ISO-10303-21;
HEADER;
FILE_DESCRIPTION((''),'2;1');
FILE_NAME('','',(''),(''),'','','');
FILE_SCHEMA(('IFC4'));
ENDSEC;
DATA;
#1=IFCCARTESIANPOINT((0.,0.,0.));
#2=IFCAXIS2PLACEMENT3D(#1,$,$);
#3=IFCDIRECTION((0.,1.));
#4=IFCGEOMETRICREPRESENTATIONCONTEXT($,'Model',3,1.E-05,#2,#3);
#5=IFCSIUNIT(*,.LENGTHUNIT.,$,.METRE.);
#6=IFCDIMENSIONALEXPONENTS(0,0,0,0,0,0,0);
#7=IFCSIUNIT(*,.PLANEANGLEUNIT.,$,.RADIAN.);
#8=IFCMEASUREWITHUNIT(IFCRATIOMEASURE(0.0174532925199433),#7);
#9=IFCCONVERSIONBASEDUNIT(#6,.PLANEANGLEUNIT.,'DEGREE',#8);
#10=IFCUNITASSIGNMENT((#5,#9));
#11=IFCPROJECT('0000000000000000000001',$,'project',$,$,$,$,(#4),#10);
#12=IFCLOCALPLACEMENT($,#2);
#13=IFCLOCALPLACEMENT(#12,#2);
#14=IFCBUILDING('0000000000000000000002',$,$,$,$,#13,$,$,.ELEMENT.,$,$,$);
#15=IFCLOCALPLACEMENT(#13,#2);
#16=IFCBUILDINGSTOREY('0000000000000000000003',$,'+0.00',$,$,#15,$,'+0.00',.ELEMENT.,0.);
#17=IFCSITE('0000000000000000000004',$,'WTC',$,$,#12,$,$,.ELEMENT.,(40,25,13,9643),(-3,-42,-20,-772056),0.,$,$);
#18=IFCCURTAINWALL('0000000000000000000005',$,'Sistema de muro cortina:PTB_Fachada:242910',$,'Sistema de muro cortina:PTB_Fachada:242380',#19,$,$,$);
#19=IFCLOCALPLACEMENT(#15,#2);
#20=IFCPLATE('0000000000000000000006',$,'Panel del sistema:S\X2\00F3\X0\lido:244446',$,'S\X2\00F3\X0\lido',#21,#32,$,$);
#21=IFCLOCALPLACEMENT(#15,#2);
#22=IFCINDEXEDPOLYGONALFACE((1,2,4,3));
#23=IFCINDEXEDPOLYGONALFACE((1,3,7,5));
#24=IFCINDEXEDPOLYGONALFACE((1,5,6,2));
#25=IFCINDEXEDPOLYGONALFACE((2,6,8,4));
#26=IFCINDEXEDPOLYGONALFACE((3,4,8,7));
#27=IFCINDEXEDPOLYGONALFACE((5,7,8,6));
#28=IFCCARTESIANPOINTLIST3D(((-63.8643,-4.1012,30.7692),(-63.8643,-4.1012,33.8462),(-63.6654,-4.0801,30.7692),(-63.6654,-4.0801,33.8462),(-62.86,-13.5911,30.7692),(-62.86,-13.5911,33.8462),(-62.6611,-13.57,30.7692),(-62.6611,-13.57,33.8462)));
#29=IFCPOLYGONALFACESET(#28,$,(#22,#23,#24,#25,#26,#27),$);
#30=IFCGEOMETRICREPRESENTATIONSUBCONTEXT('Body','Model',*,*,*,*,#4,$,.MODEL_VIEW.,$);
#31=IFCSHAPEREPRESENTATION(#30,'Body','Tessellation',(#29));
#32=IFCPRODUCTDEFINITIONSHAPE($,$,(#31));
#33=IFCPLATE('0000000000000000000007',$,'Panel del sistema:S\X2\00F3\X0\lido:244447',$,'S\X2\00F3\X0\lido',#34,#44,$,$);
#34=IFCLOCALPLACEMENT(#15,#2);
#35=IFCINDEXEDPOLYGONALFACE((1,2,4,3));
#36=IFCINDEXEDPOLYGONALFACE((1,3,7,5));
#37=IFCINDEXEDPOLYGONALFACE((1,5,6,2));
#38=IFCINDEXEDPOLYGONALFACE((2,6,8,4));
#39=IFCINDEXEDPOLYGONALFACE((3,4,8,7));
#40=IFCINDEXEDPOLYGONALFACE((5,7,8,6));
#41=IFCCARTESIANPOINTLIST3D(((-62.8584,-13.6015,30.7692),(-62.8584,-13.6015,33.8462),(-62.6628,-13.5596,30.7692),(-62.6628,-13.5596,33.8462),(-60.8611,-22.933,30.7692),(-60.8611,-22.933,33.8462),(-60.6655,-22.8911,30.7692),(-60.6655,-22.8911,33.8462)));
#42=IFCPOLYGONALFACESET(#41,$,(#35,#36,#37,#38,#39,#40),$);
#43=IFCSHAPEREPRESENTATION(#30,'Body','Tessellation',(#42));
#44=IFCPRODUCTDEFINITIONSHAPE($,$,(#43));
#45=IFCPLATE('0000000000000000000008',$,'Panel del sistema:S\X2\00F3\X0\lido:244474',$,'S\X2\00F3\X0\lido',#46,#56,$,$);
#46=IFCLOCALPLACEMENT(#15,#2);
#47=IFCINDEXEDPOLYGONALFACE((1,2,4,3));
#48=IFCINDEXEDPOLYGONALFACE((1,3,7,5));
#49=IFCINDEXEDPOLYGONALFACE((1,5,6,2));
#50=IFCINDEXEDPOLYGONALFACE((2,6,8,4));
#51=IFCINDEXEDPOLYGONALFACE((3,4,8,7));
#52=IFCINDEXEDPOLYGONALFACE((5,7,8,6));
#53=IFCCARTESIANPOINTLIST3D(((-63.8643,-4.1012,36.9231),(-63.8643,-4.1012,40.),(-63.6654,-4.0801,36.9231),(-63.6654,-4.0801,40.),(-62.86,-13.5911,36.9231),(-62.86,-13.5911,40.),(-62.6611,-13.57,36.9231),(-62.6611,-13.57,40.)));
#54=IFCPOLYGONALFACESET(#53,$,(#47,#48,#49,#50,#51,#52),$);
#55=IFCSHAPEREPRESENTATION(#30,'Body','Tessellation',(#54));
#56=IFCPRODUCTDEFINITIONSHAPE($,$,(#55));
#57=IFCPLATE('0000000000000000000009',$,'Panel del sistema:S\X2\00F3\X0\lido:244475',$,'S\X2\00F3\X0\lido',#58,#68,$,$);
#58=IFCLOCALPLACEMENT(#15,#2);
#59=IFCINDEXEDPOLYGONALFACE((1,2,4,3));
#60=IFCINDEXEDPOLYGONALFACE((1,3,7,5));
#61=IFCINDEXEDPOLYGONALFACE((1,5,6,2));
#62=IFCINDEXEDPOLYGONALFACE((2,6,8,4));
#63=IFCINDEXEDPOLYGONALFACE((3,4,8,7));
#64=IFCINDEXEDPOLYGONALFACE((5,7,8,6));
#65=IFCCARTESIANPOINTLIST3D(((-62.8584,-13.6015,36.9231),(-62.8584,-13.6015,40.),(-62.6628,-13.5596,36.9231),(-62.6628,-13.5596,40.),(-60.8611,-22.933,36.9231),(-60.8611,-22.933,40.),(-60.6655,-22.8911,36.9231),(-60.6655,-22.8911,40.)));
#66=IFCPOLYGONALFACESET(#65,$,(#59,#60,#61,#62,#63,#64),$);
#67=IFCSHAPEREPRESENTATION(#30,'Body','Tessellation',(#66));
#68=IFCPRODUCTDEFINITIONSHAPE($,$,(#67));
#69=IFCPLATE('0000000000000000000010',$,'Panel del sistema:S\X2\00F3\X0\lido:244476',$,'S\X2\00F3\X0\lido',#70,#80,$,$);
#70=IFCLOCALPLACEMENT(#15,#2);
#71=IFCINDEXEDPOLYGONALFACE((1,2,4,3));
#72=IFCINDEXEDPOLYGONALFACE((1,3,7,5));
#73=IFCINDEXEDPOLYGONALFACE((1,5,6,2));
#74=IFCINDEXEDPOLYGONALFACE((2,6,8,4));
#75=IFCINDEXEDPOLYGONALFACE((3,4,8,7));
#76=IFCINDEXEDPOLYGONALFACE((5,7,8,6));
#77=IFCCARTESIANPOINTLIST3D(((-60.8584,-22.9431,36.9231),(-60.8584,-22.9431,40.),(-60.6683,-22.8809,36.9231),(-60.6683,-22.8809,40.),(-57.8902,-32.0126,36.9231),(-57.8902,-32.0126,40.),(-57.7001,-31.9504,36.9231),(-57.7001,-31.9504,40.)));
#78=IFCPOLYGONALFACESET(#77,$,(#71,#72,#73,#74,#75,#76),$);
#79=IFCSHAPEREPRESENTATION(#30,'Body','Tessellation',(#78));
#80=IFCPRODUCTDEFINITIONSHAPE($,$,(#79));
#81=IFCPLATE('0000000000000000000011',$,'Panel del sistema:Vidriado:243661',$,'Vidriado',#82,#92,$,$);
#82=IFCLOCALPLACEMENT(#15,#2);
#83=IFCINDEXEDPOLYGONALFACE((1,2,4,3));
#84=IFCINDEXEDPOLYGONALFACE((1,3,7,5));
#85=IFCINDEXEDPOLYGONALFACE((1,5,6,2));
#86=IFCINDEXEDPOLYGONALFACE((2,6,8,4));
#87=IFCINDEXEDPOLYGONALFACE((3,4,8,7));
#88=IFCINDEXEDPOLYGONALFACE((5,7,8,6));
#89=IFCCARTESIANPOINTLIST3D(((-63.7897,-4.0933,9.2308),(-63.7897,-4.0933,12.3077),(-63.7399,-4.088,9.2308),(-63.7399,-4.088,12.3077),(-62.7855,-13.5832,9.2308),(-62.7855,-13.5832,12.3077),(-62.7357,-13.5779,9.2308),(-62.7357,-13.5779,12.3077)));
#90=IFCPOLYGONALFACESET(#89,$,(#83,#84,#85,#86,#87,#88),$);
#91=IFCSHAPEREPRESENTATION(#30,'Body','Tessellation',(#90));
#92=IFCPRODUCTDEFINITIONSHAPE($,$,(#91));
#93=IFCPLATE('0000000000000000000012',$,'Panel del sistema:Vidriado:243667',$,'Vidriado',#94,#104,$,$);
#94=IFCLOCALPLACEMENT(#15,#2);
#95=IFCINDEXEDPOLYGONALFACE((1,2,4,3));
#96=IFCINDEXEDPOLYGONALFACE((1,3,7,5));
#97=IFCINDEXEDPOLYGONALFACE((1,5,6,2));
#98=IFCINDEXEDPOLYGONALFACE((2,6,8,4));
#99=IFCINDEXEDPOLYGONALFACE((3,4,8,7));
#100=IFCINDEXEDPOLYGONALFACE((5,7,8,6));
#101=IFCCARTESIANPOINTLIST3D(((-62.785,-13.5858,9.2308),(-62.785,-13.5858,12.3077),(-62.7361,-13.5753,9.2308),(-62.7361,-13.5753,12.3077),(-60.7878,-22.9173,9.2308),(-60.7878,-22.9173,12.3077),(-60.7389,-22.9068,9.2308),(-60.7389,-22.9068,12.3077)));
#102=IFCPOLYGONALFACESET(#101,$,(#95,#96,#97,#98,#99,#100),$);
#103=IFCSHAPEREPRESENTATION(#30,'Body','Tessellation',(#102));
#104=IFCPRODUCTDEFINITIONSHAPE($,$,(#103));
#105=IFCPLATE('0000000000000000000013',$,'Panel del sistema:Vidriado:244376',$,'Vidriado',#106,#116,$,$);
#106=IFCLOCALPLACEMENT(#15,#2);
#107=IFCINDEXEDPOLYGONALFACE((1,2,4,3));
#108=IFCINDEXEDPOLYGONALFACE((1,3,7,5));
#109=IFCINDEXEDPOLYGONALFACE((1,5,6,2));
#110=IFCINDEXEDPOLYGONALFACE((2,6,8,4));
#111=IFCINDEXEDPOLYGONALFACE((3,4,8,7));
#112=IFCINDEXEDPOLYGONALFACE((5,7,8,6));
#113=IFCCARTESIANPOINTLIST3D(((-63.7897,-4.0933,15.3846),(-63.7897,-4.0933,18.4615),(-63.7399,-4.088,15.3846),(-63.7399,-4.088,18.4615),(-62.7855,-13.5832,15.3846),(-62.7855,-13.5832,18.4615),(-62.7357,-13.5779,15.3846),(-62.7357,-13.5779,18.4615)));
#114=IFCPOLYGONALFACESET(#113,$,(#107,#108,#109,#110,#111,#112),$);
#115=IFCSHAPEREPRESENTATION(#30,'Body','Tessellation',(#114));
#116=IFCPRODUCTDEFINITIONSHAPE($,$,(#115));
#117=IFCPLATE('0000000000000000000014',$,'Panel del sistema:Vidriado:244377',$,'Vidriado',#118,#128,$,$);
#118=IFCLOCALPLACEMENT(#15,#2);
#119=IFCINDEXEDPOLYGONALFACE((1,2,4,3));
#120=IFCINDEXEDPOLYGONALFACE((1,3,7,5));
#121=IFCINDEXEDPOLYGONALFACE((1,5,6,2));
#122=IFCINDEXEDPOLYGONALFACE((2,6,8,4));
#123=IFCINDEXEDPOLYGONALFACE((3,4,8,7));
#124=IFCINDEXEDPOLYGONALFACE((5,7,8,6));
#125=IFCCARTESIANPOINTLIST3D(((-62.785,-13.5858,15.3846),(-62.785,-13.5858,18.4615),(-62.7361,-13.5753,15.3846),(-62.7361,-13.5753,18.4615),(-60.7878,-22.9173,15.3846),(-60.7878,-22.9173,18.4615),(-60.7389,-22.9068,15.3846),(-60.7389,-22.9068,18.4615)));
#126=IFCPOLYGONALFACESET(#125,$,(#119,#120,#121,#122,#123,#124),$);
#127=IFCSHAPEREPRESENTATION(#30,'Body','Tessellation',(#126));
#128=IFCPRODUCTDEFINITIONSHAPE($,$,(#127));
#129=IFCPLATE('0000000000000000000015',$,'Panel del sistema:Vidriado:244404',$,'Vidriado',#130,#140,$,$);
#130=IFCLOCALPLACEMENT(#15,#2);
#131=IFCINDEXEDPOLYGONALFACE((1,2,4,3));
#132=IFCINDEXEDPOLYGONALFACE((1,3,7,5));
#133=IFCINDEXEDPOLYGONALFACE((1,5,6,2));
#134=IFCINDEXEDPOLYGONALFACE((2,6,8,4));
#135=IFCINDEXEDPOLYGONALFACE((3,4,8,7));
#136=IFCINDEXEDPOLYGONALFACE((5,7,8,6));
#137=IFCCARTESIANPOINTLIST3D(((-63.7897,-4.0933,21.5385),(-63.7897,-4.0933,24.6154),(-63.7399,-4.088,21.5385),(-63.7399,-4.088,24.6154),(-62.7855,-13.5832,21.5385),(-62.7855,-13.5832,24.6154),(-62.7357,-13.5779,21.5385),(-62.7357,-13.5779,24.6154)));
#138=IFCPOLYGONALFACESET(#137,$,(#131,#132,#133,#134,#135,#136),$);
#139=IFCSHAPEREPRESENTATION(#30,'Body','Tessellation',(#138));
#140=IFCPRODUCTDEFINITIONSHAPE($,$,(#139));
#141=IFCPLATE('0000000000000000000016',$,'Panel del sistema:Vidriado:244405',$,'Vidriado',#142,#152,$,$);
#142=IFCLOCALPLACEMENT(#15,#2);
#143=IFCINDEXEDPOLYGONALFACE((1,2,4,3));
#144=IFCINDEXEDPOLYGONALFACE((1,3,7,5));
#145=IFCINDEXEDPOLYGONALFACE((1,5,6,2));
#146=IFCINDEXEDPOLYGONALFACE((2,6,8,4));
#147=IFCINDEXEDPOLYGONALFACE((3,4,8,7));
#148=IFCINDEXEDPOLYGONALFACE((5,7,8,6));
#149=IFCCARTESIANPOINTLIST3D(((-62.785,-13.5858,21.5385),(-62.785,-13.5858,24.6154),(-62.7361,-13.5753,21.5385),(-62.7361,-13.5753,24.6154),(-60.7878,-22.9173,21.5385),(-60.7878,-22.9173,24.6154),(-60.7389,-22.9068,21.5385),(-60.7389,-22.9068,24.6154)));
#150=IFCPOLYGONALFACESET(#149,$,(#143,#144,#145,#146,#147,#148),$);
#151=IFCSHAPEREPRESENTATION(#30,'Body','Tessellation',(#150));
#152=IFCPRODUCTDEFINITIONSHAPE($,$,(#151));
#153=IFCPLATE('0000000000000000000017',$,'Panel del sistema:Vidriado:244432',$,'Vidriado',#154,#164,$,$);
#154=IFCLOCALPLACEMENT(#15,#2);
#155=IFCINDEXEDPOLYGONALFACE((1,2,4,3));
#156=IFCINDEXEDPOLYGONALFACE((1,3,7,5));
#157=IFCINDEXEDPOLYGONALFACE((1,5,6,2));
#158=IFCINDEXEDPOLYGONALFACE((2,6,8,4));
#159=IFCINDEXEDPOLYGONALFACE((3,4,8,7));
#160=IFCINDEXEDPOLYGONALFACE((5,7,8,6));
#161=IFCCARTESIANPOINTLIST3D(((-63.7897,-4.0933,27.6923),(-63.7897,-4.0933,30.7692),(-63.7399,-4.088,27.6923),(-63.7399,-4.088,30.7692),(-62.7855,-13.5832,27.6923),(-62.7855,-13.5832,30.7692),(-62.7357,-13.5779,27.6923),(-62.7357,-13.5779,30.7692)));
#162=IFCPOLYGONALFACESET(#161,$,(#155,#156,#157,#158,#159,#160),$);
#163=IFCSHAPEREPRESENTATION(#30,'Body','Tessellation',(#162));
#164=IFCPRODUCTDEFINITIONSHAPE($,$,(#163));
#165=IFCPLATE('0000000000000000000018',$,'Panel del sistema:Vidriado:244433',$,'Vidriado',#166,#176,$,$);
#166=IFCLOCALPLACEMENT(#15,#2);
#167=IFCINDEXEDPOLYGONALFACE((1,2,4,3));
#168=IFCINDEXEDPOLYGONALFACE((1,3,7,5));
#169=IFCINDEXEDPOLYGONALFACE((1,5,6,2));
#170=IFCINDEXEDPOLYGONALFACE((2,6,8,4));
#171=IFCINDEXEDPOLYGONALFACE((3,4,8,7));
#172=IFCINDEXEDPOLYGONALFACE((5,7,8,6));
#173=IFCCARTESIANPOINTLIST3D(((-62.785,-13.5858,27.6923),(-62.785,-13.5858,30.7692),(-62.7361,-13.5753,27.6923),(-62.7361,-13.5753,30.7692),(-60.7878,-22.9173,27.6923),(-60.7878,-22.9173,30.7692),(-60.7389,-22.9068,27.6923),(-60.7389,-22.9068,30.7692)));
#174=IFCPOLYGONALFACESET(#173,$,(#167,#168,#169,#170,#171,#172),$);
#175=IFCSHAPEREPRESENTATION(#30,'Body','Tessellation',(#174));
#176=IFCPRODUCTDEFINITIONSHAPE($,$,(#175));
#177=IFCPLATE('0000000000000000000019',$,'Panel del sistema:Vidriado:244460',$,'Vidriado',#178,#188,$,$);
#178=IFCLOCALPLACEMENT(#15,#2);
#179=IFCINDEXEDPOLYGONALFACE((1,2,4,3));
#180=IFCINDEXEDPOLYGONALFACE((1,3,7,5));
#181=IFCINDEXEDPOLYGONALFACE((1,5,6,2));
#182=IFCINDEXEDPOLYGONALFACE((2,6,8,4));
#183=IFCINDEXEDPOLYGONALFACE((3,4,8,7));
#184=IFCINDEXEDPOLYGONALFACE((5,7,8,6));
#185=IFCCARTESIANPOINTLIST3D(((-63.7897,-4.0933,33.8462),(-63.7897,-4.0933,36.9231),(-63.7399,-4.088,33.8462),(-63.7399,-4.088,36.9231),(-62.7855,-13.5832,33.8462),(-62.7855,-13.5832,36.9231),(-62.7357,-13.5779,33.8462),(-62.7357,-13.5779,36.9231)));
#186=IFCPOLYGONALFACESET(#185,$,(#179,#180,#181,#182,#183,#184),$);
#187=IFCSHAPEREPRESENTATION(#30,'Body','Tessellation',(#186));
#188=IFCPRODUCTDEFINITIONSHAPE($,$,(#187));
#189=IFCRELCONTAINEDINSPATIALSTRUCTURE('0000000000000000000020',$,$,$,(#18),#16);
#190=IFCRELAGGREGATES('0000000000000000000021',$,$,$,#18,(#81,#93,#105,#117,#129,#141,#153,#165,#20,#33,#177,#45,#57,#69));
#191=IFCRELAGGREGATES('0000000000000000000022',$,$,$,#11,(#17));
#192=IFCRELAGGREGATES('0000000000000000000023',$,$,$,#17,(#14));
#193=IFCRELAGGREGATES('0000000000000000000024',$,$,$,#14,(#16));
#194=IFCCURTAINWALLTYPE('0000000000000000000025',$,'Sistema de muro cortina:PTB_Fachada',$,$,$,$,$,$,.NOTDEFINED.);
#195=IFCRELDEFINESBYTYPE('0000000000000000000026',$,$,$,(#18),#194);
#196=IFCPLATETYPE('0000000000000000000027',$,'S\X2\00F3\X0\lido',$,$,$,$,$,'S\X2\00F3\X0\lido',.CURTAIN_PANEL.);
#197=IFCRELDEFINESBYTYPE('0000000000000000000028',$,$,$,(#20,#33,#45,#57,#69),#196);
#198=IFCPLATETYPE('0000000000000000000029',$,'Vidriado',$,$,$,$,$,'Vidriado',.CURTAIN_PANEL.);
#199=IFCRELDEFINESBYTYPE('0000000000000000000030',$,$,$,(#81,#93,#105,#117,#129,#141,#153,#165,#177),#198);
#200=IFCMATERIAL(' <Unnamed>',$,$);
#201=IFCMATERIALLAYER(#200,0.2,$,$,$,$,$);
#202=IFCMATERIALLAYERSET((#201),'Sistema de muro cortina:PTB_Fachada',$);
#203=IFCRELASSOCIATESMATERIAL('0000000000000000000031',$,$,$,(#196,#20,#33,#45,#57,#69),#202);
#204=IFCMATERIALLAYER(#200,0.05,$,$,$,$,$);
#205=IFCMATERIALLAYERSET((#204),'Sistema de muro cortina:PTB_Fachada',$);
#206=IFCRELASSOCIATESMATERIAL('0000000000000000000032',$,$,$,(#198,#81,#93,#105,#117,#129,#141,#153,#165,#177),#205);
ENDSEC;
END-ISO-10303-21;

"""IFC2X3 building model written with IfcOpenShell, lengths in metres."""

from ifc_helpers import new_model, entity, si_unit, converted_unit, direction, frame, frame_2d, origin, origin_2d_with_axis, place, context, subcontext, project, spatial, rectangle, extrude, source, transform, mapped, material, layer, layer_set, layer_usage, type_object, type_shapes, element, aggregate, save


model = new_model("IFC2X3")

# Units and contexts
model_context = context("Model", 3, precision=1e-05, world=origin(), true_north=direction((0.0, 1.0)))
body_context = subcontext(model_context, "Body", "Model", "MODEL_VIEW")
ifc_project = project(units=[si_unit("LENGTHUNIT", "METRE"), converted_unit("PLANEANGLEUNIT", "DEGREE", entity("IfcRatioMeasure", 0.0174532925199433), si_unit("PLANEANGLEUNIT", "RADIAN"), dimensions=[0, 0, 0, 0, 0, 0, 0])], contexts=[model_context])

# Site, building, storey
site_placement = place(None, origin())
site = spatial("IfcSite", under=ifc_project, at=site_placement, Name="WTC", CompositionType="ELEMENT", RefLatitude=(40, 25, 13, 9643), RefLongitude=(-3, -42, -20, -772056), RefElevation=0.0)
building_placement = place(site_placement, origin())
building = spatial("IfcBuilding", under=site, at=building_placement, CompositionType="ELEMENT")
storey_placement = place(building_placement, origin())
storey = spatial("IfcBuildingStorey", under=building, at=storey_placement, Name="+0.00", LongName="+0.00", CompositionType="ELEMENT", Elevation=0.0)

# Curtain wall, plates
curtain_wall_type = type_object("IfcCurtainWallType", Name="Sistema de muro cortina:PTB_Fachada", PredefinedType="NOTDEFINED")
curtain_wall_placement = place(storey_placement, origin())
curtain_wall = element("IfcCurtainWall", 1, at=curtain_wall_placement, inside=storey, type_object=curtain_wall_type, Name="Sistema de muro cortina:PTB_Fachada:242910", ObjectType="Sistema de muro cortina:PTB_Fachada:242380")
ifc_material_1 = material(Name=" <Unnamed>")
ifc_layer_1 = layer(ifc_material_1, 0.2)
ifc_layer_set_1 = layer_set([ifc_layer_1], Name="Sistema de muro cortina:PTB_Fachada")
plate_type_1 = type_object("IfcPlateType", Name="Sólido", ElementType="Sólido", PredefinedType="CURTAIN_PANEL", material=ifc_layer_set_1)
shared_shape_1 = source(origin(), body_context, "Body", "SweptSolid", [
    extrude(rectangle(XDim=0.2, YDim=9.5428, at=frame_2d((0.0, 0.0), x_axis=(1.0, 0.0))), frame((0.0, 0.0, 0.0), z_axis=(0.0, 0.0, 1.0), x_axis=(0.0, 1.0, 0.0)), (0.0, 0.0, 1.0), 3.0769),
])
type_shapes(plate_type_1, [shared_shape_1])
ifc_layer_usage_1 = layer_usage(ifc_layer_set_1, "AXIS3", "POSITIVE", 0.0)
plate_1_placement = place(curtain_wall_placement, frame((-63.2627, -8.8356, 30.7692), z_axis=(0.0, 0.0, 1.0), x_axis=(0.105232, -0.994448, 0.0)))
plate_1 = element("IfcPlate", 2, at=plate_1_placement, type_object=plate_type_1, material=ifc_layer_usage_1, Name="Panel del sistema:Sólido:244446", ObjectType="Sólido", context=body_context, shape_type="MappedRepresentation", body=[
    mapped(shared_shape_1, transform((0.0, 0.0, 0.0), scale=1.0)),
])
ifc_layer_usage_2 = layer_usage(ifc_layer_set_1, "AXIS3", "POSITIVE", 0.0)
plate_2_placement = place(curtain_wall_placement, frame((-61.762, -18.2463, 30.7692), z_axis=(0.0, 0.0, 1.0), x_axis=(0.209296, -0.977852, 0.0)))
plate_2 = element("IfcPlate", 3, at=plate_2_placement, type_object=plate_type_1, material=ifc_layer_usage_2, Name="Panel del sistema:Sólido:244447", ObjectType="Sólido", context=body_context, shape_type="MappedRepresentation", body=[
    mapped(shared_shape_1, transform((0.0, 0.0, 0.0), scale=1.0)),
])
ifc_layer_usage_3 = layer_usage(ifc_layer_set_1, "AXIS3", "POSITIVE", 0.0)
plate_3_placement = place(curtain_wall_placement, frame((-63.2627, -8.8356, 36.9231), z_axis=(0.0, 0.0, 1.0), x_axis=(0.105232, -0.994448, 0.0)))
plate_3 = element("IfcPlate", 4, at=plate_3_placement, type_object=plate_type_1, material=ifc_layer_usage_3, Name="Panel del sistema:Sólido:244474", ObjectType="Sólido", context=body_context, shape_type="MappedRepresentation", body=[
    mapped(shared_shape_1, transform((0.0, 0.0, 0.0), scale=1.0)),
])
ifc_layer_usage_4 = layer_usage(ifc_layer_set_1, "AXIS3", "POSITIVE", 0.0)
plate_4_placement = place(curtain_wall_placement, frame((-61.762, -18.2463, 36.9231), z_axis=(0.0, 0.0, 1.0), x_axis=(0.209296, -0.977852, 0.0)))
plate_4 = element("IfcPlate", 5, at=plate_4_placement, type_object=plate_type_1, material=ifc_layer_usage_4, Name="Panel del sistema:Sólido:244475", ObjectType="Sólido", context=body_context, shape_type="MappedRepresentation", body=[
    mapped(shared_shape_1, transform((0.0, 0.0, 0.0), scale=1.0)),
])
ifc_layer_usage_5 = layer_usage(ifc_layer_set_1, "AXIS3", "POSITIVE", 0.0)
plate_5_placement = place(curtain_wall_placement, frame((-59.2792, -27.4468, 36.9231), z_axis=(0.0, 0.0, 1.0), x_axis=(0.311036, -0.950398, 0.0)))
plate_5 = element("IfcPlate", 6, at=plate_5_placement, type_object=plate_type_1, material=ifc_layer_usage_5, Name="Panel del sistema:Sólido:244476", ObjectType="Sólido", context=body_context, shape_type="MappedRepresentation", body=[
    mapped(shared_shape_1, transform((0.0, 0.0, 0.0), scale=1.0)),
])
ifc_layer_2 = layer(ifc_material_1, 0.05)
ifc_layer_set_2 = layer_set([ifc_layer_2], Name="Sistema de muro cortina:PTB_Fachada")
ifc_layer_usage_6 = layer_usage(ifc_layer_set_2, "AXIS3", "POSITIVE", 0.0)
plate_type_2 = type_object("IfcPlateType", Name="Vidriado", ElementType="Vidriado", PredefinedType="CURTAIN_PANEL", material=ifc_layer_set_2)
shared_shape_2 = source(origin(), body_context, "Body", "SweptSolid", [
    extrude(rectangle(XDim=0.05, YDim=9.5428, at=origin_2d_with_axis()), frame((0.0, 0.0, 0.0), z_axis=(0.0, 0.0, 1.0), x_axis=(0.0, 1.0, 0.0)), (0.0, 0.0, 1.0), 3.0769),
])
type_shapes(plate_type_2, [shared_shape_2])
plate_6_placement = place(curtain_wall_placement, frame((-63.2627, -8.8356, 9.2308), z_axis=(0.0, 0.0, 1.0), x_axis=(0.105232, -0.994448, 0.0)))
plate_6 = element("IfcPlate", 7, at=plate_6_placement, type_object=plate_type_2, material=ifc_layer_usage_6, Name="Panel del sistema:Vidriado:243661", ObjectType="Vidriado", context=body_context, shape_type="MappedRepresentation", body=[
    mapped(shared_shape_2, transform((0.0, 0.0, 0.0), scale=1.0)),
])
ifc_layer_usage_7 = layer_usage(ifc_layer_set_2, "AXIS3", "POSITIVE", 0.0)
plate_7_placement = place(curtain_wall_placement, frame((-61.762, -18.2463, 9.2308), z_axis=(0.0, 0.0, 1.0), x_axis=(0.209296, -0.977852, 0.0)))
plate_7 = element("IfcPlate", 8, at=plate_7_placement, type_object=plate_type_2, material=ifc_layer_usage_7, Name="Panel del sistema:Vidriado:243667", ObjectType="Vidriado", context=body_context, shape_type="MappedRepresentation", body=[
    mapped(shared_shape_2, transform((0.0, 0.0, 0.0), scale=1.0)),
])
ifc_layer_usage_8 = layer_usage(ifc_layer_set_2, "AXIS3", "POSITIVE", 0.0)
plate_8_placement = place(curtain_wall_placement, frame((-63.2627, -8.8356, 15.3846), z_axis=(0.0, 0.0, 1.0), x_axis=(0.105232, -0.994448, 0.0)))
plate_8 = element("IfcPlate", 9, at=plate_8_placement, type_object=plate_type_2, material=ifc_layer_usage_8, Name="Panel del sistema:Vidriado:244376", ObjectType="Vidriado", context=body_context, shape_type="MappedRepresentation", body=[
    mapped(shared_shape_2, transform((0.0, 0.0, 0.0), scale=1.0)),
])
ifc_layer_usage_9 = layer_usage(ifc_layer_set_2, "AXIS3", "POSITIVE", 0.0)
plate_9_placement = place(curtain_wall_placement, frame((-61.762, -18.2463, 15.3846), z_axis=(0.0, 0.0, 1.0), x_axis=(0.209296, -0.977852, 0.0)))
plate_9 = element("IfcPlate", 10, at=plate_9_placement, type_object=plate_type_2, material=ifc_layer_usage_9, Name="Panel del sistema:Vidriado:244377", ObjectType="Vidriado", context=body_context, shape_type="MappedRepresentation", body=[
    mapped(shared_shape_2, transform((0.0, 0.0, 0.0), scale=1.0)),
])
ifc_layer_usage_10 = layer_usage(ifc_layer_set_2, "AXIS3", "POSITIVE", 0.0)
plate_10_placement = place(curtain_wall_placement, frame((-63.2627, -8.8356, 21.5385), z_axis=(0.0, 0.0, 1.0), x_axis=(0.105232, -0.994448, 0.0)))
plate_10 = element("IfcPlate", 11, at=plate_10_placement, type_object=plate_type_2, material=ifc_layer_usage_10, Name="Panel del sistema:Vidriado:244404", ObjectType="Vidriado", context=body_context, shape_type="MappedRepresentation", body=[
    mapped(shared_shape_2, transform((0.0, 0.0, 0.0), scale=1.0)),
])
ifc_layer_usage_11 = layer_usage(ifc_layer_set_2, "AXIS3", "POSITIVE", 0.0)
plate_11_placement = place(curtain_wall_placement, frame((-61.762, -18.2463, 21.5385), z_axis=(0.0, 0.0, 1.0), x_axis=(0.209296, -0.977852, 0.0)))
plate_11 = element("IfcPlate", 12, at=plate_11_placement, type_object=plate_type_2, material=ifc_layer_usage_11, Name="Panel del sistema:Vidriado:244405", ObjectType="Vidriado", context=body_context, shape_type="MappedRepresentation", body=[
    mapped(shared_shape_2, transform((0.0, 0.0, 0.0), scale=1.0)),
])
ifc_layer_usage_12 = layer_usage(ifc_layer_set_2, "AXIS3", "POSITIVE", 0.0)
plate_12_placement = place(curtain_wall_placement, frame((-63.2627, -8.8356, 27.6923), z_axis=(0.0, 0.0, 1.0), x_axis=(0.105232, -0.994448, 0.0)))
plate_12 = element("IfcPlate", 13, at=plate_12_placement, type_object=plate_type_2, material=ifc_layer_usage_12, Name="Panel del sistema:Vidriado:244432", ObjectType="Vidriado", context=body_context, shape_type="MappedRepresentation", body=[
    mapped(shared_shape_2, transform((0.0, 0.0, 0.0), scale=1.0)),
])
ifc_layer_usage_13 = layer_usage(ifc_layer_set_2, "AXIS3", "POSITIVE", 0.0)
plate_13_placement = place(curtain_wall_placement, frame((-61.762, -18.2463, 27.6923), z_axis=(0.0, 0.0, 1.0), x_axis=(0.209296, -0.977852, 0.0)))
plate_13 = element("IfcPlate", 14, at=plate_13_placement, type_object=plate_type_2, material=ifc_layer_usage_13, Name="Panel del sistema:Vidriado:244433", ObjectType="Vidriado", context=body_context, shape_type="MappedRepresentation", body=[
    mapped(shared_shape_2, transform((0.0, 0.0, 0.0), scale=1.0)),
])
ifc_layer_usage_14 = layer_usage(ifc_layer_set_2, "AXIS3", "POSITIVE", 0.0)
plate_14_placement = place(curtain_wall_placement, frame((-63.2627, -8.8356, 33.8462), z_axis=(0.0, 0.0, 1.0), x_axis=(0.105232, -0.994448, 0.0)))
plate_14 = element("IfcPlate", 15, at=plate_14_placement, type_object=plate_type_2, material=ifc_layer_usage_14, Name="Panel del sistema:Vidriado:244460", ObjectType="Vidriado", context=body_context, shape_type="MappedRepresentation", body=[
    mapped(shared_shape_2, transform((0.0, 0.0, 0.0), scale=1.0)),
])
aggregate(curtain_wall, [plate_6, plate_7, plate_8, plate_9, plate_10, plate_11, plate_12, plate_13, plate_1, plate_2, plate_14, plate_3, plate_4, plate_5])

save(model, "model.ifc")
